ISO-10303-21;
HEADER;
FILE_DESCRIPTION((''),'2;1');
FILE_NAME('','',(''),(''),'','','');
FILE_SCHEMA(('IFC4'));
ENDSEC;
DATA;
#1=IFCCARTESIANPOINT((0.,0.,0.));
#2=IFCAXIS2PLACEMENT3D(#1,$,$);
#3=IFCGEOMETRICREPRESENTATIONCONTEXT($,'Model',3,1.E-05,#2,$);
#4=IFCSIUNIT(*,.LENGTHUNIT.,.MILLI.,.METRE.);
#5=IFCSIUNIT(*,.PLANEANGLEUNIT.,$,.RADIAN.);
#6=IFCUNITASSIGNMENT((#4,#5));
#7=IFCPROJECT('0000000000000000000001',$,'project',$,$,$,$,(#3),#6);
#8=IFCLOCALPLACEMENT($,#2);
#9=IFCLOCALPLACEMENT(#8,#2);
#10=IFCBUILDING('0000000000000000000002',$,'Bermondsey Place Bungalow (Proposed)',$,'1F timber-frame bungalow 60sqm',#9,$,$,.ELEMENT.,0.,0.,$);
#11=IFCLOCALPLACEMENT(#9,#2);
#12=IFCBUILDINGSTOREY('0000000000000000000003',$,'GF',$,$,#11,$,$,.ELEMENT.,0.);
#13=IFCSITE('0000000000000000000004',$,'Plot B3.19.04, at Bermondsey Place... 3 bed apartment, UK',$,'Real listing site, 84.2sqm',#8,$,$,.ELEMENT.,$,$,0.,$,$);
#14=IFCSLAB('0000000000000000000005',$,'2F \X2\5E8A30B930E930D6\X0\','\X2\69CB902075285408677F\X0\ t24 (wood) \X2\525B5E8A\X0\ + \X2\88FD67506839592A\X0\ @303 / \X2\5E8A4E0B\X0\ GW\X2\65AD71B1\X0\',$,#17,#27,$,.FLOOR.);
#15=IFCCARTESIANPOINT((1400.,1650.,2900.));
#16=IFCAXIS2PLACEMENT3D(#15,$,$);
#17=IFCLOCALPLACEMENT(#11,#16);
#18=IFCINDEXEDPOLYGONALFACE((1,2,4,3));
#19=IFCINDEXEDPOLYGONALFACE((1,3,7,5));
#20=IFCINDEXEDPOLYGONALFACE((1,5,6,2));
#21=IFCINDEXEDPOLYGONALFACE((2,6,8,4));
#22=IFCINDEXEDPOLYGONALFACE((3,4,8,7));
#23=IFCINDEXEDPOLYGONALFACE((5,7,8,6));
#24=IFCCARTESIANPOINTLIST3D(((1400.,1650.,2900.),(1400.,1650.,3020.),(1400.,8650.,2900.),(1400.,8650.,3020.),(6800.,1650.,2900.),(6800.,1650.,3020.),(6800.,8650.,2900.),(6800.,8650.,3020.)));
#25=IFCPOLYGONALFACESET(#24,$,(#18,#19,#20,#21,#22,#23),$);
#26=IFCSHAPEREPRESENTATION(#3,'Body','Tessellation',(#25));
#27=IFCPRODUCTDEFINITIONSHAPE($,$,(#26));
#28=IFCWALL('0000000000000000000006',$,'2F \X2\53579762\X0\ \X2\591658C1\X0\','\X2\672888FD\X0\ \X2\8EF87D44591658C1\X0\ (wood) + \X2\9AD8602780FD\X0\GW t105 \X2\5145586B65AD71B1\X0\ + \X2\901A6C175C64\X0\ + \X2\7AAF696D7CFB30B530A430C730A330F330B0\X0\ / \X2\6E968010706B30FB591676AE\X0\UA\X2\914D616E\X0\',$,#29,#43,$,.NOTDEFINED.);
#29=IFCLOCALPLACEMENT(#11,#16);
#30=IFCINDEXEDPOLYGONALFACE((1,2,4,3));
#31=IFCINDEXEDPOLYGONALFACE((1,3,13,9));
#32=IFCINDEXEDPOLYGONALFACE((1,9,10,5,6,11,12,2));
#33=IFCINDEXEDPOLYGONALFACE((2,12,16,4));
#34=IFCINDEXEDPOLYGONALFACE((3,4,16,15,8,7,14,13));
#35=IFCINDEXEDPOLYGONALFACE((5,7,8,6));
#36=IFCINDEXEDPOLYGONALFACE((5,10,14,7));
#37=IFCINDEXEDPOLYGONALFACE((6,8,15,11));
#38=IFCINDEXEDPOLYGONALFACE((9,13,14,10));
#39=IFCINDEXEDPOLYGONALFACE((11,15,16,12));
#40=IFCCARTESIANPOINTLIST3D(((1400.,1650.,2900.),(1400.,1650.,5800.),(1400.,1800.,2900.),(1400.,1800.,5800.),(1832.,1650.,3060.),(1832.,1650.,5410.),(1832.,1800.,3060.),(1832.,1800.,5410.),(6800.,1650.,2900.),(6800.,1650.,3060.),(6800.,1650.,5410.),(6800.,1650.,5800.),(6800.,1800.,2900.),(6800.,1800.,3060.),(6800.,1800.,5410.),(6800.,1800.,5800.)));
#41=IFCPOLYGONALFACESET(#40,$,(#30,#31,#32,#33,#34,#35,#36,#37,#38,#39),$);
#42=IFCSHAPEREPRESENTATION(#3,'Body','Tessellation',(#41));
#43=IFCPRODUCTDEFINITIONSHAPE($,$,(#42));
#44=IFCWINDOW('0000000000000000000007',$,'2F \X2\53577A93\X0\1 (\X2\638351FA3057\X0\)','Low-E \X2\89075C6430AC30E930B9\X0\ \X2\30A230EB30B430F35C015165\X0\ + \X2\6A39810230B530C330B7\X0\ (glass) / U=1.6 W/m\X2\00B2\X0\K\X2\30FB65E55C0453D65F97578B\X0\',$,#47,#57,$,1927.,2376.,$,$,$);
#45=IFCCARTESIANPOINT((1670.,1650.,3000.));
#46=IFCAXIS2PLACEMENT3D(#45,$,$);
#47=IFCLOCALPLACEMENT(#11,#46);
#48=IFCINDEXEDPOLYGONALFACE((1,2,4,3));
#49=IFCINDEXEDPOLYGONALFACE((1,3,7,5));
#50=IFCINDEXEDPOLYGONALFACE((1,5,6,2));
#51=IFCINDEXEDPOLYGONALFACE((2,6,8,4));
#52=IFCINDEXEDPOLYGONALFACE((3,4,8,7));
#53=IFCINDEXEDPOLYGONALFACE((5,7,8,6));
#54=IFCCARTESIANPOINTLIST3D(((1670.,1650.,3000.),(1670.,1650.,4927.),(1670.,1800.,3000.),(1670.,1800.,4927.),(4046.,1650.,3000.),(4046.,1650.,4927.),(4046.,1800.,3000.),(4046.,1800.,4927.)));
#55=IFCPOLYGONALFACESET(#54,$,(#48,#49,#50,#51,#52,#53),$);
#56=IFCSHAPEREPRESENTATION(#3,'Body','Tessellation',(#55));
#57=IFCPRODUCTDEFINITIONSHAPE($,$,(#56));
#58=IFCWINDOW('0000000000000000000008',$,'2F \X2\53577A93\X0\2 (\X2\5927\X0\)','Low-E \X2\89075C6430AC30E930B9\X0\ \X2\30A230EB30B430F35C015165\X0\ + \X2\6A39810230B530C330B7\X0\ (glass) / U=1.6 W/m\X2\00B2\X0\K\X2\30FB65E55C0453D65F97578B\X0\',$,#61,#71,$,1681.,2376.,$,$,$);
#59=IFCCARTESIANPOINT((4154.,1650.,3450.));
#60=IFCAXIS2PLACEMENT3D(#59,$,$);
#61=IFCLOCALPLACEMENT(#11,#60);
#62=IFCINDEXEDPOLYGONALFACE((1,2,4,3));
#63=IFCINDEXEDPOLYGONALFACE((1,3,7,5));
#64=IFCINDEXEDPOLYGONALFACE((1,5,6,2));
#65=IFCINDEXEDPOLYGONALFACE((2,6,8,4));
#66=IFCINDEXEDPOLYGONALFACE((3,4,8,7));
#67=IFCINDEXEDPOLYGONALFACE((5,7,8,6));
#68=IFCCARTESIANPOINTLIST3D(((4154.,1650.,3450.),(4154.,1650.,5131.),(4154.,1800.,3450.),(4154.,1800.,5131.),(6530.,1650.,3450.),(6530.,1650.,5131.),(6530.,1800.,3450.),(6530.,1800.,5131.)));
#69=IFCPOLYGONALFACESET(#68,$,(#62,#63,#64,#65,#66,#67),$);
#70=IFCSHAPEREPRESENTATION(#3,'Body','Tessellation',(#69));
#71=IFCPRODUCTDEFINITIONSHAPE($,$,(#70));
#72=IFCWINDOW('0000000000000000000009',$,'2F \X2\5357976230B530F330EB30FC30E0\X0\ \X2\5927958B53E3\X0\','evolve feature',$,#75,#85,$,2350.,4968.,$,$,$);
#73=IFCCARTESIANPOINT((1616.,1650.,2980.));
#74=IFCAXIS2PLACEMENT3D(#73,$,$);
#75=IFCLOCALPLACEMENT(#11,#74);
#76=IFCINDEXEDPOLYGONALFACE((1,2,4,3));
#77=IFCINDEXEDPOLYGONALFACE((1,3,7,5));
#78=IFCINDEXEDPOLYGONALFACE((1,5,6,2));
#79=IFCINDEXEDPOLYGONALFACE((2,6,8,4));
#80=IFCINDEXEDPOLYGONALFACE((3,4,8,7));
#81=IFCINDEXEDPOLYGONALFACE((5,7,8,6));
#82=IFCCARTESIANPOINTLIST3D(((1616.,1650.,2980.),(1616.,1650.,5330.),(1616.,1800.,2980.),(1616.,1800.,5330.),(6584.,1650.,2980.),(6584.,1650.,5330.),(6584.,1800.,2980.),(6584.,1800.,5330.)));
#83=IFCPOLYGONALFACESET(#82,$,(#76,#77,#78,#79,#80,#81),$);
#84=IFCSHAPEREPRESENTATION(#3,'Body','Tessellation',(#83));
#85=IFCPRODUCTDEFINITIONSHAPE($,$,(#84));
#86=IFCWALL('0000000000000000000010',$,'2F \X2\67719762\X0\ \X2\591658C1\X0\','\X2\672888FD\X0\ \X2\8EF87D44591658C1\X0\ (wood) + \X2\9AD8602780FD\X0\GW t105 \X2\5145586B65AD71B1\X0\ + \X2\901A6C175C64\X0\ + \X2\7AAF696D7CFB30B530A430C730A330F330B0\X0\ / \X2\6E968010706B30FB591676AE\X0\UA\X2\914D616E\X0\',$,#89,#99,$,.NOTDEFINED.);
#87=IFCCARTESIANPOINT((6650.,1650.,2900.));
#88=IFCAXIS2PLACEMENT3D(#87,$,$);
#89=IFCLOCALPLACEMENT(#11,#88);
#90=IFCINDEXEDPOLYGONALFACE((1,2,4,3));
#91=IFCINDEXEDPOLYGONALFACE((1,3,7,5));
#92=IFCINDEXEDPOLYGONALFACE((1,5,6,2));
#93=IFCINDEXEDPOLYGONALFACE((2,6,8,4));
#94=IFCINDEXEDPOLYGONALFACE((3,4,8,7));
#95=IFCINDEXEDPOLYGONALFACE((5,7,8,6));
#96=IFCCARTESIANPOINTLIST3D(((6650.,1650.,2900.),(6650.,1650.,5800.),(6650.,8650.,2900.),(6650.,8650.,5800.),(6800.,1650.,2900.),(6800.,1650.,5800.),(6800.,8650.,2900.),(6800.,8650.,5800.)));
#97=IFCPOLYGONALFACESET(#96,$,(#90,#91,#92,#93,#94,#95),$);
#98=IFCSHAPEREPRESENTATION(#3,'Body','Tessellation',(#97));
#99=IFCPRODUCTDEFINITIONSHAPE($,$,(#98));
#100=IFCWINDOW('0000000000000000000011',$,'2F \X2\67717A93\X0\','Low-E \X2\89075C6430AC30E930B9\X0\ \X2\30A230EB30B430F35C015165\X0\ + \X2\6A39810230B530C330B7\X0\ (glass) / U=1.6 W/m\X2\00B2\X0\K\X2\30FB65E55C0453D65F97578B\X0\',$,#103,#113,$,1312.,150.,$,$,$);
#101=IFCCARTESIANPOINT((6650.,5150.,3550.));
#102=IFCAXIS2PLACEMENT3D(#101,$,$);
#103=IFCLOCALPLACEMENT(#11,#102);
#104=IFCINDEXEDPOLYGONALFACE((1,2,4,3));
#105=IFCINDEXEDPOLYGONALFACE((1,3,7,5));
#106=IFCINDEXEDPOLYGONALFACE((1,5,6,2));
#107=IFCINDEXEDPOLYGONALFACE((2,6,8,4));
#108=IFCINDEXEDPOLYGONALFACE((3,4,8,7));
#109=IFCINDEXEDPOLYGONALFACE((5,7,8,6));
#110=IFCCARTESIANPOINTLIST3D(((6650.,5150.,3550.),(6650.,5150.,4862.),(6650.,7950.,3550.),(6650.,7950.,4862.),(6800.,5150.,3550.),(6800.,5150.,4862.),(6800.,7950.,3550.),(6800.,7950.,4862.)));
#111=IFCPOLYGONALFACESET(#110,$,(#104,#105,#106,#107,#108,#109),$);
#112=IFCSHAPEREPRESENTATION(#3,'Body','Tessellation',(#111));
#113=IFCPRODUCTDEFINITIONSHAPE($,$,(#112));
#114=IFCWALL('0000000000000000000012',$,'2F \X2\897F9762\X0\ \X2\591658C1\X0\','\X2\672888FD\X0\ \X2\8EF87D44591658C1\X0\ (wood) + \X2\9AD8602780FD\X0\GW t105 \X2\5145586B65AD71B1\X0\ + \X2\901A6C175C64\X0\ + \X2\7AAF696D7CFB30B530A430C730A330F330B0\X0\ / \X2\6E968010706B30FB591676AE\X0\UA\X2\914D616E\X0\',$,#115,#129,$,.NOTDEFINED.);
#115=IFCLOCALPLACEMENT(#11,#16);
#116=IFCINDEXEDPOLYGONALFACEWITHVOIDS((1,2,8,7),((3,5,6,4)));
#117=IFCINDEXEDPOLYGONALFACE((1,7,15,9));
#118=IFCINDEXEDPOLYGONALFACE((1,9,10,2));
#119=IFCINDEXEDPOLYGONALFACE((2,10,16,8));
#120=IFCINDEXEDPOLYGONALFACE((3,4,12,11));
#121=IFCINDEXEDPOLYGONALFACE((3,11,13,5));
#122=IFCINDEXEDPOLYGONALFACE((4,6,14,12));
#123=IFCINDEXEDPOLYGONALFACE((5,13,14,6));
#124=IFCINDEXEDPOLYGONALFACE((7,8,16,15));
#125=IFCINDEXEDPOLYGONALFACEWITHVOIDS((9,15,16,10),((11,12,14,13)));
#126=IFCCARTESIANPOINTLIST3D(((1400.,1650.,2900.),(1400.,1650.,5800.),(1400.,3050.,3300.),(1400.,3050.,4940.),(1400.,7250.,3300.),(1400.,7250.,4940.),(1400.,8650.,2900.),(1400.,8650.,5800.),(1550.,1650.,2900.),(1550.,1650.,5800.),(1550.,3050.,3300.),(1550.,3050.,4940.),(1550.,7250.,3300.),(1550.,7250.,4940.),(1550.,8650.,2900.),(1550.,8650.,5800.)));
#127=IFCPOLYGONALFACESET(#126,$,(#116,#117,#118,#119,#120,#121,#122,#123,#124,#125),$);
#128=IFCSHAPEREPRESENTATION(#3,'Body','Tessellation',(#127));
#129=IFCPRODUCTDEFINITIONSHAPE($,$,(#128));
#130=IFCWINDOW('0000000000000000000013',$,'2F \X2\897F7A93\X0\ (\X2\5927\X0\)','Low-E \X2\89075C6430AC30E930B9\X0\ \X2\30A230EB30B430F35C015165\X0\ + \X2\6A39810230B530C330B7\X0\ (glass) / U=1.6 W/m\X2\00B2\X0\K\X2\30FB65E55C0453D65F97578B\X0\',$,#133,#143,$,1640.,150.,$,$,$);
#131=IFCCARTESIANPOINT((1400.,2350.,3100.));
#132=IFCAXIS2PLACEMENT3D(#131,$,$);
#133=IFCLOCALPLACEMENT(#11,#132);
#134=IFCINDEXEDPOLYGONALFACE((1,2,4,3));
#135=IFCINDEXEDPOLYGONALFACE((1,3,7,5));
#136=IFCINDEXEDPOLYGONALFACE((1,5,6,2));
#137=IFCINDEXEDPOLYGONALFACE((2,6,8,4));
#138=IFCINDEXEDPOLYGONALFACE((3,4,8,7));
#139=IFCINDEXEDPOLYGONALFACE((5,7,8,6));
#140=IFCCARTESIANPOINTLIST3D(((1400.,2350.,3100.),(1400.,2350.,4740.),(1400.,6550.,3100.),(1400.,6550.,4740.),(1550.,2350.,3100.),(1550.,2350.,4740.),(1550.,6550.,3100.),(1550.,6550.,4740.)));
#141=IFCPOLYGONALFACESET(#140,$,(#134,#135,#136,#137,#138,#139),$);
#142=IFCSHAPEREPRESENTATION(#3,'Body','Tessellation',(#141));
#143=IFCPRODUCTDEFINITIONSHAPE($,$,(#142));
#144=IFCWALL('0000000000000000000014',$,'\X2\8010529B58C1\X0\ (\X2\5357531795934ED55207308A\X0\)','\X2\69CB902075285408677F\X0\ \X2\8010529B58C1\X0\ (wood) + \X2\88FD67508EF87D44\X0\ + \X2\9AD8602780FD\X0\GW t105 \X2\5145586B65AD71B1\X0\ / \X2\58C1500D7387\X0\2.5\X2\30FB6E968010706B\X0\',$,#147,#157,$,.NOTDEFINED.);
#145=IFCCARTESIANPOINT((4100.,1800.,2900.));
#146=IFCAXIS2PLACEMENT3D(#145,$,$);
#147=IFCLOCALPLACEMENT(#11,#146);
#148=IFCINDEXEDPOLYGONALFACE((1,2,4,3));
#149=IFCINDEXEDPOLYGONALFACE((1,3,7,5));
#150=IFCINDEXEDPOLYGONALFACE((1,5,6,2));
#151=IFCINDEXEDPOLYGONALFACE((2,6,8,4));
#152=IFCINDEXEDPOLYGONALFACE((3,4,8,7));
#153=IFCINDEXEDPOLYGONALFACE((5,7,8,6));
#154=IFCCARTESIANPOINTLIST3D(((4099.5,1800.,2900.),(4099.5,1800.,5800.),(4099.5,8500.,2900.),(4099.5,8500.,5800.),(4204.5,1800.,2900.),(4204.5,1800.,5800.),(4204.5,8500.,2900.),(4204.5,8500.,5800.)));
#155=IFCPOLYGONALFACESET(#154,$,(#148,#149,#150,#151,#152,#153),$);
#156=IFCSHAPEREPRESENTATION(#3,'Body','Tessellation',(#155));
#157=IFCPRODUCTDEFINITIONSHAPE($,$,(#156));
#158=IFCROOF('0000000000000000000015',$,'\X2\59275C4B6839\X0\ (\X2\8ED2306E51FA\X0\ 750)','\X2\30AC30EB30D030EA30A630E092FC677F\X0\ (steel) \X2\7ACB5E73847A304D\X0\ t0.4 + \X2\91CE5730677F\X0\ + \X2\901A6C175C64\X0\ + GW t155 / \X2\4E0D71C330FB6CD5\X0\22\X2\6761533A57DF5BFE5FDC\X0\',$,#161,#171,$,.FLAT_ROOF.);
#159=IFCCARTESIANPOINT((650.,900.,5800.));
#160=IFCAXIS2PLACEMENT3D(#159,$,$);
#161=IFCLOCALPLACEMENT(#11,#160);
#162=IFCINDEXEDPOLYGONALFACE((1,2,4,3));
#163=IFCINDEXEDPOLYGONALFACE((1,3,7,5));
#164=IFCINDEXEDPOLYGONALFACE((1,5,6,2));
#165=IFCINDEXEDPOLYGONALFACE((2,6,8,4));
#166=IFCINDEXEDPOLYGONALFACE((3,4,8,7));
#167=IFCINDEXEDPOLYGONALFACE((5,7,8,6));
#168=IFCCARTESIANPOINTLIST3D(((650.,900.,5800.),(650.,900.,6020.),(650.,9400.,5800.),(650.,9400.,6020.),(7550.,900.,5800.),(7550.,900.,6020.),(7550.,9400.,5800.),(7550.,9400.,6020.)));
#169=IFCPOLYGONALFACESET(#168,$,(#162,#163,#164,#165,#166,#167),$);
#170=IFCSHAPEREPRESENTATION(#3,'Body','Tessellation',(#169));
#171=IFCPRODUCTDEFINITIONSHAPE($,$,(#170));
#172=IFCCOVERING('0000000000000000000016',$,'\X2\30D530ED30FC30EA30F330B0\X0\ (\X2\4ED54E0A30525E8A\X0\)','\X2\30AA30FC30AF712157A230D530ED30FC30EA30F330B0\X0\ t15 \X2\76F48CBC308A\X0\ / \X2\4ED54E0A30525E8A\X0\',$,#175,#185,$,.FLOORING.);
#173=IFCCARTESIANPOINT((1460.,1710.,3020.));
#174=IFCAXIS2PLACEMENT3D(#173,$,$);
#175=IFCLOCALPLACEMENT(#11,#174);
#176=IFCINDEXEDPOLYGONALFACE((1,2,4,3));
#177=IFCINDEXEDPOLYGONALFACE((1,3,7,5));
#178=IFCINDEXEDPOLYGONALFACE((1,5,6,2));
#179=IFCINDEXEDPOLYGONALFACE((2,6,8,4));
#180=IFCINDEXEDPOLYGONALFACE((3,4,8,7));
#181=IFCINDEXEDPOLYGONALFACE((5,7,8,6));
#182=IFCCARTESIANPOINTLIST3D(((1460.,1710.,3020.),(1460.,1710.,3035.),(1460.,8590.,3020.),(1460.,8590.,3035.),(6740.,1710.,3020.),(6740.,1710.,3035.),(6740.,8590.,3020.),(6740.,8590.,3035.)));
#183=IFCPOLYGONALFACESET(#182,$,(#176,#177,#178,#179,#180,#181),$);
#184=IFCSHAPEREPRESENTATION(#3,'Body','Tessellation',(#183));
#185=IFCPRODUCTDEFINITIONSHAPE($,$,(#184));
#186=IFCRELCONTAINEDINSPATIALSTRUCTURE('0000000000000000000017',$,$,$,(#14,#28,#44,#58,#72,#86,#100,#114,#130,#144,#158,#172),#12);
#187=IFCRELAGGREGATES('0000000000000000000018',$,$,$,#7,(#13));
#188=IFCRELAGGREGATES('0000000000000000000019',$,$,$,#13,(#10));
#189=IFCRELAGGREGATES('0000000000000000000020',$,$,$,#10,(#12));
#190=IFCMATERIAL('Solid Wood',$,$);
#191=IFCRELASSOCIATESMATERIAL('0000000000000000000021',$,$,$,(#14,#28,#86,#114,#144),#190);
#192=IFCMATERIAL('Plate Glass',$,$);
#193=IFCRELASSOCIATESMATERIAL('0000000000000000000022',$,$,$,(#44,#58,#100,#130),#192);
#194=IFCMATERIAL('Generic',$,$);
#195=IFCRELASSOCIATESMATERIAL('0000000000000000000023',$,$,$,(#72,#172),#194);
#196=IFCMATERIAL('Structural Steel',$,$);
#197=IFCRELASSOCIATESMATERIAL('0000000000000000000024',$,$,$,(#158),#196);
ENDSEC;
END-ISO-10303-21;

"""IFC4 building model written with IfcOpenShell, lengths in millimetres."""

from ifc_helpers import new_model, si_unit, frame, frame_2d, origin, place, context, project, spatial, rectangle, extrude, material, element, fill, save


model = new_model("IFC4")

# Units and contexts
model_context = context("Model", 3, precision=1e-05, world=origin())
ifc_project = project(units=[si_unit("LENGTHUNIT", "METRE", prefix="MILLI"), si_unit("PLANEANGLEUNIT", "RADIAN")], contexts=[model_context])

# Site, building, storey
site_placement = place(None, origin())
site = spatial("IfcSite", under=ifc_project, at=site_placement, Name="Plot B3.19.04, at Bermondsey Place... 3 bed apartment, UK", ObjectType="Real listing site, 84.2sqm", CompositionType="ELEMENT", RefElevation=0.0)
building_placement = place(site_placement, origin())
building = spatial("IfcBuilding", under=site, at=building_placement, Name="Bermondsey Place Bungalow (Proposed)", ObjectType="1F timber-frame bungalow 60sqm", CompositionType="ELEMENT", ElevationOfRefHeight=0.0, ElevationOfTerrain=0.0)
storey_placement = place(building_placement, origin())
storey = spatial("IfcBuildingStorey", under=building, at=storey_placement, Name="GF", CompositionType="ELEMENT", Elevation=0.0)

# Slab
ifc_material_1 = material(Name="Solid Wood")
slab_placement = place(storey_placement, frame((1400.0, 1650.0, 2900.0)))
element("IfcSlab", 1, at=slab_placement, inside=storey, material=ifc_material_1, Name="2F 床スラブ", Description="構造用合板 t24 (wood) 剛床 + 製材根太 @303 / 床下 GW断熱", PredefinedType="FLOOR", context=model_context, shape_type="SweptSolid", body=[
    extrude(rectangle(XDim=5400.0, YDim=7000.0, at=frame_2d((2700.0, 3500.0))), frame((1400.0, 1650.0, 2900.0)), (0.0, 0.0, 1.0), 120.0),
])

# Wall, openings, windows
wall_1_placement = place(storey_placement, frame((1400.0, 1650.0, 2900.0)))
wall_1 = element("IfcWall", 2, at=wall_1_placement, inside=storey, material=ifc_material_1, Name="2F 南面 外壁", Description="木製 軸組外壁 (wood) + 高性能GW t105 充填断熱 + 通気層 + 窯業系サイディング / 準耐火・外皮UA配慮", PredefinedType="NOTDEFINED", context=model_context, shape_type="SweptSolid", body=[
    extrude(rectangle(XDim=5400.0, YDim=150.0, at=frame_2d((2700.0, 75.0))), frame((1400.0, 1650.0, 2900.0)), (0.0, 0.0, 1.0), 2900.0),
])
opening_1_placement = place(storey_placement, frame((1670.0, 1650.0, 3000.0)))
opening_1 = element("IfcOpeningElement", 3, at=opening_1_placement, cuts=wall_1, PredefinedType="NOTDEFINED", context=model_context, shape_type="SweptSolid", body=[
    extrude(rectangle(XDim=2376.0, YDim=150.0, at=frame_2d((1188.0, 75.0))), frame((1670.0, 1650.0, 3000.0)), (0.0, 0.0, 1.0), 1927.0),
])
opening_2_placement = place(storey_placement, frame((4154.0, 1650.0, 3450.0)))
opening_2 = element("IfcOpeningElement", 4, at=opening_2_placement, cuts=wall_1, PredefinedType="NOTDEFINED", context=model_context, shape_type="SweptSolid", body=[
    extrude(rectangle(XDim=2376.0, YDim=150.0, at=frame_2d((1188.0, 75.0))), frame((4154.0, 1650.0, 3450.0)), (0.0, 0.0, 1.0), 1681.0),
])
opening_3_placement = place(storey_placement, frame((1616.0, 1650.0, 2980.0)))
opening_3 = element("IfcOpeningElement", 5, at=opening_3_placement, cuts=wall_1, PredefinedType="NOTDEFINED", context=model_context, shape_type="SweptSolid", body=[
    extrude(rectangle(XDim=4968.0, YDim=150.0, at=frame_2d((2484.0, 75.0))), frame((1616.0, 1650.0, 2980.0)), (0.0, 0.0, 1.0), 2350.0),
])
ifc_material_2 = material(Name="Plate Glass")
window_1_placement = place(storey_placement, frame((1670.0, 1650.0, 3000.0)))
window_1 = element("IfcWindow", 6, at=window_1_placement, inside=storey, material=ifc_material_2, Name="2F 南窓1 (掃出し)", Description="Low-E 複層ガラス アルゴン封入 + 樹脂サッシ (glass) / U=1.6 W/m²K・日射取得型", OverallHeight=1927.0, OverallWidth=2376.0, context=model_context, shape_type="SweptSolid", body=[
    extrude(rectangle(XDim=2376.0, YDim=150.0, at=frame_2d((1188.0, 75.0))), frame((1670.0, 1650.0, 3000.0)), (0.0, 0.0, 1.0), 1927.0),
])
fill(opening_1, window_1)
window_2_placement = place(storey_placement, frame((4154.0, 1650.0, 3450.0)))
window_2 = element("IfcWindow", 7, at=window_2_placement, inside=storey, material=ifc_material_2, Name="2F 南窓2 (大)", Description="Low-E 複層ガラス アルゴン封入 + 樹脂サッシ (glass) / U=1.6 W/m²K・日射取得型", OverallHeight=1681.0, OverallWidth=2376.0, context=model_context, shape_type="SweptSolid", body=[
    extrude(rectangle(XDim=2376.0, YDim=150.0, at=frame_2d((1188.0, 75.0))), frame((4154.0, 1650.0, 3450.0)), (0.0, 0.0, 1.0), 1681.0),
])
fill(opening_2, window_2)
ifc_material_3 = material(Name="Generic")
window_3_placement = place(storey_placement, frame((1616.0, 1650.0, 2980.0)))
window_3 = element("IfcWindow", 8, at=window_3_placement, inside=storey, material=ifc_material_3, Name="2F 南面サンルーム 大開口", Description="evolve feature", OverallHeight=2350.0, OverallWidth=4968.0, context=model_context, shape_type="SweptSolid", body=[
    extrude(rectangle(XDim=4968.0, YDim=150.0, at=frame_2d((2484.0, 75.0))), frame((1616.0, 1650.0, 2980.0)), (0.0, 0.0, 1.0), 2350.0),
])
fill(opening_3, window_3)

# Walls, openings, windows
wall_2_placement = place(storey_placement, frame((6650.0, 1650.0, 2900.0)))
wall_2 = element("IfcWall", 9, at=wall_2_placement, inside=storey, material=ifc_material_1, Name="2F 東面 外壁", Description="木製 軸組外壁 (wood) + 高性能GW t105 充填断熱 + 通気層 + 窯業系サイディング / 準耐火・外皮UA配慮", PredefinedType="NOTDEFINED", context=model_context, shape_type="SweptSolid", body=[
    extrude(rectangle(XDim=150.0, YDim=7000.0, at=frame_2d((75.0, 3500.0))), frame((6650.0, 1650.0, 2900.0)), (0.0, 0.0, 1.0), 2900.0),
])
opening_4_placement = place(storey_placement, frame((6650.0, 5150.0, 3550.0)))
opening_4 = element("IfcOpeningElement", 10, at=opening_4_placement, cuts=wall_2, PredefinedType="NOTDEFINED", context=model_context, shape_type="SweptSolid", body=[
    extrude(rectangle(XDim=150.0, YDim=2800.0, at=frame_2d((75.0, 1400.0))), frame((6650.0, 5150.0, 3550.0)), (0.0, 0.0, 1.0), 1312.0),
])
window_4_placement = place(storey_placement, frame((6650.0, 5150.0, 3550.0)))
window_4 = element("IfcWindow", 11, at=window_4_placement, inside=storey, material=ifc_material_2, Name="2F 東窓", Description="Low-E 複層ガラス アルゴン封入 + 樹脂サッシ (glass) / U=1.6 W/m²K・日射取得型", OverallHeight=1312.0, OverallWidth=150.0, context=model_context, shape_type="SweptSolid", body=[
    extrude(rectangle(XDim=150.0, YDim=2800.0, at=frame_2d((75.0, 1400.0))), frame((6650.0, 5150.0, 3550.0)), (0.0, 0.0, 1.0), 1312.0),
])
fill(opening_4, window_4)
wall_3_placement = place(storey_placement, frame((1400.0, 1650.0, 2900.0)))
wall_3 = element("IfcWall", 12, at=wall_3_placement, inside=storey, material=ifc_material_1, Name="2F 西面 外壁", Description="木製 軸組外壁 (wood) + 高性能GW t105 充填断熱 + 通気層 + 窯業系サイディング / 準耐火・外皮UA配慮", PredefinedType="NOTDEFINED", context=model_context, shape_type="SweptSolid", body=[
    extrude(rectangle(XDim=150.0, YDim=7000.0, at=frame_2d((75.0, 3500.0))), frame((1400.0, 1650.0, 2900.0)), (0.0, 0.0, 1.0), 2900.0),
])
opening_5_placement = place(storey_placement, frame((1400.0, 2350.0, 3100.0)))
opening_5 = element("IfcOpeningElement", 13, at=opening_5_placement, cuts=wall_3, PredefinedType="NOTDEFINED", context=model_context, shape_type="SweptSolid", body=[
    extrude(rectangle(XDim=150.0, YDim=4200.0, at=frame_2d((75.0, 2100.0))), frame((1400.0, 2350.0, 3100.0)), (0.0, 0.0, 1.0), 1640.0),
])
window_5_placement = place(storey_placement, frame((1400.0, 2350.0, 3100.0)))
window_5 = element("IfcWindow", 14, at=window_5_placement, inside=storey, material=ifc_material_2, Name="2F 西窓 (大)", Description="Low-E 複層ガラス アルゴン封入 + 樹脂サッシ (glass) / U=1.6 W/m²K・日射取得型", OverallHeight=1640.0, OverallWidth=150.0, context=model_context, shape_type="SweptSolid", body=[
    extrude(rectangle(XDim=150.0, YDim=4200.0, at=frame_2d((75.0, 2100.0))), frame((1400.0, 2350.0, 3100.0)), (0.0, 0.0, 1.0), 1640.0),
])
fill(opening_5, window_5)

# Wall
wall_4_placement = place(storey_placement, frame((4100.0, 1800.0, 2900.0)))
element("IfcWall", 15, at=wall_4_placement, inside=storey, material=ifc_material_1, Name="耐力壁 (南北間仕切り)", Description="構造用合板 耐力壁 (wood) + 製材軸組 + 高性能GW t105 充填断熱 / 壁倍率2.5・準耐火", PredefinedType="NOTDEFINED", context=model_context, shape_type="SweptSolid", body=[
    extrude(rectangle(XDim=105.0, YDim=6700.0, at=frame_2d((52.0, 3350.0))), frame((4100.0, 1800.0, 2900.0)), (0.0, 0.0, 1.0), 2900.0),
])

# Roof
ifc_material_4 = material(Name="Structural Steel")
roof_placement = place(storey_placement, frame((650.0, 900.0, 5800.0)))
element("IfcRoof", 16, at=roof_placement, inside=storey, material=ifc_material_4, Name="大屋根 (軒の出 750)", Description="ガルバリウム鋼板 (steel) 立平葺き t0.4 + 野地板 + 通気層 + GW t155 / 不燃・法22条区域対応", PredefinedType="FLAT_ROOF", context=model_context, shape_type="SweptSolid", body=[
    extrude(rectangle(XDim=6900.0, YDim=8500.0, at=frame_2d((3450.0, 4250.0))), frame((650.0, 900.0, 5800.0)), (0.0, 0.0, 1.0), 220.0),
])

# Covering
covering_placement = place(storey_placement, frame((1460.0, 1710.0, 3020.0)))
element("IfcCovering", 17, at=covering_placement, inside=storey, material=ifc_material_3, Name="フローリング (仕上げ床)", Description="オーク無垢フローリング t15 直貼り / 仕上げ床", PredefinedType="FLOORING", context=model_context, shape_type="SweptSolid", body=[
    extrude(rectangle(XDim=5280.0, YDim=6880.0, at=frame_2d((2640.0, 3440.0))), frame((1460.0, 1710.0, 3020.0)), (0.0, 0.0, 1.0), 15.0),
])

save(model, "model.ifc")
